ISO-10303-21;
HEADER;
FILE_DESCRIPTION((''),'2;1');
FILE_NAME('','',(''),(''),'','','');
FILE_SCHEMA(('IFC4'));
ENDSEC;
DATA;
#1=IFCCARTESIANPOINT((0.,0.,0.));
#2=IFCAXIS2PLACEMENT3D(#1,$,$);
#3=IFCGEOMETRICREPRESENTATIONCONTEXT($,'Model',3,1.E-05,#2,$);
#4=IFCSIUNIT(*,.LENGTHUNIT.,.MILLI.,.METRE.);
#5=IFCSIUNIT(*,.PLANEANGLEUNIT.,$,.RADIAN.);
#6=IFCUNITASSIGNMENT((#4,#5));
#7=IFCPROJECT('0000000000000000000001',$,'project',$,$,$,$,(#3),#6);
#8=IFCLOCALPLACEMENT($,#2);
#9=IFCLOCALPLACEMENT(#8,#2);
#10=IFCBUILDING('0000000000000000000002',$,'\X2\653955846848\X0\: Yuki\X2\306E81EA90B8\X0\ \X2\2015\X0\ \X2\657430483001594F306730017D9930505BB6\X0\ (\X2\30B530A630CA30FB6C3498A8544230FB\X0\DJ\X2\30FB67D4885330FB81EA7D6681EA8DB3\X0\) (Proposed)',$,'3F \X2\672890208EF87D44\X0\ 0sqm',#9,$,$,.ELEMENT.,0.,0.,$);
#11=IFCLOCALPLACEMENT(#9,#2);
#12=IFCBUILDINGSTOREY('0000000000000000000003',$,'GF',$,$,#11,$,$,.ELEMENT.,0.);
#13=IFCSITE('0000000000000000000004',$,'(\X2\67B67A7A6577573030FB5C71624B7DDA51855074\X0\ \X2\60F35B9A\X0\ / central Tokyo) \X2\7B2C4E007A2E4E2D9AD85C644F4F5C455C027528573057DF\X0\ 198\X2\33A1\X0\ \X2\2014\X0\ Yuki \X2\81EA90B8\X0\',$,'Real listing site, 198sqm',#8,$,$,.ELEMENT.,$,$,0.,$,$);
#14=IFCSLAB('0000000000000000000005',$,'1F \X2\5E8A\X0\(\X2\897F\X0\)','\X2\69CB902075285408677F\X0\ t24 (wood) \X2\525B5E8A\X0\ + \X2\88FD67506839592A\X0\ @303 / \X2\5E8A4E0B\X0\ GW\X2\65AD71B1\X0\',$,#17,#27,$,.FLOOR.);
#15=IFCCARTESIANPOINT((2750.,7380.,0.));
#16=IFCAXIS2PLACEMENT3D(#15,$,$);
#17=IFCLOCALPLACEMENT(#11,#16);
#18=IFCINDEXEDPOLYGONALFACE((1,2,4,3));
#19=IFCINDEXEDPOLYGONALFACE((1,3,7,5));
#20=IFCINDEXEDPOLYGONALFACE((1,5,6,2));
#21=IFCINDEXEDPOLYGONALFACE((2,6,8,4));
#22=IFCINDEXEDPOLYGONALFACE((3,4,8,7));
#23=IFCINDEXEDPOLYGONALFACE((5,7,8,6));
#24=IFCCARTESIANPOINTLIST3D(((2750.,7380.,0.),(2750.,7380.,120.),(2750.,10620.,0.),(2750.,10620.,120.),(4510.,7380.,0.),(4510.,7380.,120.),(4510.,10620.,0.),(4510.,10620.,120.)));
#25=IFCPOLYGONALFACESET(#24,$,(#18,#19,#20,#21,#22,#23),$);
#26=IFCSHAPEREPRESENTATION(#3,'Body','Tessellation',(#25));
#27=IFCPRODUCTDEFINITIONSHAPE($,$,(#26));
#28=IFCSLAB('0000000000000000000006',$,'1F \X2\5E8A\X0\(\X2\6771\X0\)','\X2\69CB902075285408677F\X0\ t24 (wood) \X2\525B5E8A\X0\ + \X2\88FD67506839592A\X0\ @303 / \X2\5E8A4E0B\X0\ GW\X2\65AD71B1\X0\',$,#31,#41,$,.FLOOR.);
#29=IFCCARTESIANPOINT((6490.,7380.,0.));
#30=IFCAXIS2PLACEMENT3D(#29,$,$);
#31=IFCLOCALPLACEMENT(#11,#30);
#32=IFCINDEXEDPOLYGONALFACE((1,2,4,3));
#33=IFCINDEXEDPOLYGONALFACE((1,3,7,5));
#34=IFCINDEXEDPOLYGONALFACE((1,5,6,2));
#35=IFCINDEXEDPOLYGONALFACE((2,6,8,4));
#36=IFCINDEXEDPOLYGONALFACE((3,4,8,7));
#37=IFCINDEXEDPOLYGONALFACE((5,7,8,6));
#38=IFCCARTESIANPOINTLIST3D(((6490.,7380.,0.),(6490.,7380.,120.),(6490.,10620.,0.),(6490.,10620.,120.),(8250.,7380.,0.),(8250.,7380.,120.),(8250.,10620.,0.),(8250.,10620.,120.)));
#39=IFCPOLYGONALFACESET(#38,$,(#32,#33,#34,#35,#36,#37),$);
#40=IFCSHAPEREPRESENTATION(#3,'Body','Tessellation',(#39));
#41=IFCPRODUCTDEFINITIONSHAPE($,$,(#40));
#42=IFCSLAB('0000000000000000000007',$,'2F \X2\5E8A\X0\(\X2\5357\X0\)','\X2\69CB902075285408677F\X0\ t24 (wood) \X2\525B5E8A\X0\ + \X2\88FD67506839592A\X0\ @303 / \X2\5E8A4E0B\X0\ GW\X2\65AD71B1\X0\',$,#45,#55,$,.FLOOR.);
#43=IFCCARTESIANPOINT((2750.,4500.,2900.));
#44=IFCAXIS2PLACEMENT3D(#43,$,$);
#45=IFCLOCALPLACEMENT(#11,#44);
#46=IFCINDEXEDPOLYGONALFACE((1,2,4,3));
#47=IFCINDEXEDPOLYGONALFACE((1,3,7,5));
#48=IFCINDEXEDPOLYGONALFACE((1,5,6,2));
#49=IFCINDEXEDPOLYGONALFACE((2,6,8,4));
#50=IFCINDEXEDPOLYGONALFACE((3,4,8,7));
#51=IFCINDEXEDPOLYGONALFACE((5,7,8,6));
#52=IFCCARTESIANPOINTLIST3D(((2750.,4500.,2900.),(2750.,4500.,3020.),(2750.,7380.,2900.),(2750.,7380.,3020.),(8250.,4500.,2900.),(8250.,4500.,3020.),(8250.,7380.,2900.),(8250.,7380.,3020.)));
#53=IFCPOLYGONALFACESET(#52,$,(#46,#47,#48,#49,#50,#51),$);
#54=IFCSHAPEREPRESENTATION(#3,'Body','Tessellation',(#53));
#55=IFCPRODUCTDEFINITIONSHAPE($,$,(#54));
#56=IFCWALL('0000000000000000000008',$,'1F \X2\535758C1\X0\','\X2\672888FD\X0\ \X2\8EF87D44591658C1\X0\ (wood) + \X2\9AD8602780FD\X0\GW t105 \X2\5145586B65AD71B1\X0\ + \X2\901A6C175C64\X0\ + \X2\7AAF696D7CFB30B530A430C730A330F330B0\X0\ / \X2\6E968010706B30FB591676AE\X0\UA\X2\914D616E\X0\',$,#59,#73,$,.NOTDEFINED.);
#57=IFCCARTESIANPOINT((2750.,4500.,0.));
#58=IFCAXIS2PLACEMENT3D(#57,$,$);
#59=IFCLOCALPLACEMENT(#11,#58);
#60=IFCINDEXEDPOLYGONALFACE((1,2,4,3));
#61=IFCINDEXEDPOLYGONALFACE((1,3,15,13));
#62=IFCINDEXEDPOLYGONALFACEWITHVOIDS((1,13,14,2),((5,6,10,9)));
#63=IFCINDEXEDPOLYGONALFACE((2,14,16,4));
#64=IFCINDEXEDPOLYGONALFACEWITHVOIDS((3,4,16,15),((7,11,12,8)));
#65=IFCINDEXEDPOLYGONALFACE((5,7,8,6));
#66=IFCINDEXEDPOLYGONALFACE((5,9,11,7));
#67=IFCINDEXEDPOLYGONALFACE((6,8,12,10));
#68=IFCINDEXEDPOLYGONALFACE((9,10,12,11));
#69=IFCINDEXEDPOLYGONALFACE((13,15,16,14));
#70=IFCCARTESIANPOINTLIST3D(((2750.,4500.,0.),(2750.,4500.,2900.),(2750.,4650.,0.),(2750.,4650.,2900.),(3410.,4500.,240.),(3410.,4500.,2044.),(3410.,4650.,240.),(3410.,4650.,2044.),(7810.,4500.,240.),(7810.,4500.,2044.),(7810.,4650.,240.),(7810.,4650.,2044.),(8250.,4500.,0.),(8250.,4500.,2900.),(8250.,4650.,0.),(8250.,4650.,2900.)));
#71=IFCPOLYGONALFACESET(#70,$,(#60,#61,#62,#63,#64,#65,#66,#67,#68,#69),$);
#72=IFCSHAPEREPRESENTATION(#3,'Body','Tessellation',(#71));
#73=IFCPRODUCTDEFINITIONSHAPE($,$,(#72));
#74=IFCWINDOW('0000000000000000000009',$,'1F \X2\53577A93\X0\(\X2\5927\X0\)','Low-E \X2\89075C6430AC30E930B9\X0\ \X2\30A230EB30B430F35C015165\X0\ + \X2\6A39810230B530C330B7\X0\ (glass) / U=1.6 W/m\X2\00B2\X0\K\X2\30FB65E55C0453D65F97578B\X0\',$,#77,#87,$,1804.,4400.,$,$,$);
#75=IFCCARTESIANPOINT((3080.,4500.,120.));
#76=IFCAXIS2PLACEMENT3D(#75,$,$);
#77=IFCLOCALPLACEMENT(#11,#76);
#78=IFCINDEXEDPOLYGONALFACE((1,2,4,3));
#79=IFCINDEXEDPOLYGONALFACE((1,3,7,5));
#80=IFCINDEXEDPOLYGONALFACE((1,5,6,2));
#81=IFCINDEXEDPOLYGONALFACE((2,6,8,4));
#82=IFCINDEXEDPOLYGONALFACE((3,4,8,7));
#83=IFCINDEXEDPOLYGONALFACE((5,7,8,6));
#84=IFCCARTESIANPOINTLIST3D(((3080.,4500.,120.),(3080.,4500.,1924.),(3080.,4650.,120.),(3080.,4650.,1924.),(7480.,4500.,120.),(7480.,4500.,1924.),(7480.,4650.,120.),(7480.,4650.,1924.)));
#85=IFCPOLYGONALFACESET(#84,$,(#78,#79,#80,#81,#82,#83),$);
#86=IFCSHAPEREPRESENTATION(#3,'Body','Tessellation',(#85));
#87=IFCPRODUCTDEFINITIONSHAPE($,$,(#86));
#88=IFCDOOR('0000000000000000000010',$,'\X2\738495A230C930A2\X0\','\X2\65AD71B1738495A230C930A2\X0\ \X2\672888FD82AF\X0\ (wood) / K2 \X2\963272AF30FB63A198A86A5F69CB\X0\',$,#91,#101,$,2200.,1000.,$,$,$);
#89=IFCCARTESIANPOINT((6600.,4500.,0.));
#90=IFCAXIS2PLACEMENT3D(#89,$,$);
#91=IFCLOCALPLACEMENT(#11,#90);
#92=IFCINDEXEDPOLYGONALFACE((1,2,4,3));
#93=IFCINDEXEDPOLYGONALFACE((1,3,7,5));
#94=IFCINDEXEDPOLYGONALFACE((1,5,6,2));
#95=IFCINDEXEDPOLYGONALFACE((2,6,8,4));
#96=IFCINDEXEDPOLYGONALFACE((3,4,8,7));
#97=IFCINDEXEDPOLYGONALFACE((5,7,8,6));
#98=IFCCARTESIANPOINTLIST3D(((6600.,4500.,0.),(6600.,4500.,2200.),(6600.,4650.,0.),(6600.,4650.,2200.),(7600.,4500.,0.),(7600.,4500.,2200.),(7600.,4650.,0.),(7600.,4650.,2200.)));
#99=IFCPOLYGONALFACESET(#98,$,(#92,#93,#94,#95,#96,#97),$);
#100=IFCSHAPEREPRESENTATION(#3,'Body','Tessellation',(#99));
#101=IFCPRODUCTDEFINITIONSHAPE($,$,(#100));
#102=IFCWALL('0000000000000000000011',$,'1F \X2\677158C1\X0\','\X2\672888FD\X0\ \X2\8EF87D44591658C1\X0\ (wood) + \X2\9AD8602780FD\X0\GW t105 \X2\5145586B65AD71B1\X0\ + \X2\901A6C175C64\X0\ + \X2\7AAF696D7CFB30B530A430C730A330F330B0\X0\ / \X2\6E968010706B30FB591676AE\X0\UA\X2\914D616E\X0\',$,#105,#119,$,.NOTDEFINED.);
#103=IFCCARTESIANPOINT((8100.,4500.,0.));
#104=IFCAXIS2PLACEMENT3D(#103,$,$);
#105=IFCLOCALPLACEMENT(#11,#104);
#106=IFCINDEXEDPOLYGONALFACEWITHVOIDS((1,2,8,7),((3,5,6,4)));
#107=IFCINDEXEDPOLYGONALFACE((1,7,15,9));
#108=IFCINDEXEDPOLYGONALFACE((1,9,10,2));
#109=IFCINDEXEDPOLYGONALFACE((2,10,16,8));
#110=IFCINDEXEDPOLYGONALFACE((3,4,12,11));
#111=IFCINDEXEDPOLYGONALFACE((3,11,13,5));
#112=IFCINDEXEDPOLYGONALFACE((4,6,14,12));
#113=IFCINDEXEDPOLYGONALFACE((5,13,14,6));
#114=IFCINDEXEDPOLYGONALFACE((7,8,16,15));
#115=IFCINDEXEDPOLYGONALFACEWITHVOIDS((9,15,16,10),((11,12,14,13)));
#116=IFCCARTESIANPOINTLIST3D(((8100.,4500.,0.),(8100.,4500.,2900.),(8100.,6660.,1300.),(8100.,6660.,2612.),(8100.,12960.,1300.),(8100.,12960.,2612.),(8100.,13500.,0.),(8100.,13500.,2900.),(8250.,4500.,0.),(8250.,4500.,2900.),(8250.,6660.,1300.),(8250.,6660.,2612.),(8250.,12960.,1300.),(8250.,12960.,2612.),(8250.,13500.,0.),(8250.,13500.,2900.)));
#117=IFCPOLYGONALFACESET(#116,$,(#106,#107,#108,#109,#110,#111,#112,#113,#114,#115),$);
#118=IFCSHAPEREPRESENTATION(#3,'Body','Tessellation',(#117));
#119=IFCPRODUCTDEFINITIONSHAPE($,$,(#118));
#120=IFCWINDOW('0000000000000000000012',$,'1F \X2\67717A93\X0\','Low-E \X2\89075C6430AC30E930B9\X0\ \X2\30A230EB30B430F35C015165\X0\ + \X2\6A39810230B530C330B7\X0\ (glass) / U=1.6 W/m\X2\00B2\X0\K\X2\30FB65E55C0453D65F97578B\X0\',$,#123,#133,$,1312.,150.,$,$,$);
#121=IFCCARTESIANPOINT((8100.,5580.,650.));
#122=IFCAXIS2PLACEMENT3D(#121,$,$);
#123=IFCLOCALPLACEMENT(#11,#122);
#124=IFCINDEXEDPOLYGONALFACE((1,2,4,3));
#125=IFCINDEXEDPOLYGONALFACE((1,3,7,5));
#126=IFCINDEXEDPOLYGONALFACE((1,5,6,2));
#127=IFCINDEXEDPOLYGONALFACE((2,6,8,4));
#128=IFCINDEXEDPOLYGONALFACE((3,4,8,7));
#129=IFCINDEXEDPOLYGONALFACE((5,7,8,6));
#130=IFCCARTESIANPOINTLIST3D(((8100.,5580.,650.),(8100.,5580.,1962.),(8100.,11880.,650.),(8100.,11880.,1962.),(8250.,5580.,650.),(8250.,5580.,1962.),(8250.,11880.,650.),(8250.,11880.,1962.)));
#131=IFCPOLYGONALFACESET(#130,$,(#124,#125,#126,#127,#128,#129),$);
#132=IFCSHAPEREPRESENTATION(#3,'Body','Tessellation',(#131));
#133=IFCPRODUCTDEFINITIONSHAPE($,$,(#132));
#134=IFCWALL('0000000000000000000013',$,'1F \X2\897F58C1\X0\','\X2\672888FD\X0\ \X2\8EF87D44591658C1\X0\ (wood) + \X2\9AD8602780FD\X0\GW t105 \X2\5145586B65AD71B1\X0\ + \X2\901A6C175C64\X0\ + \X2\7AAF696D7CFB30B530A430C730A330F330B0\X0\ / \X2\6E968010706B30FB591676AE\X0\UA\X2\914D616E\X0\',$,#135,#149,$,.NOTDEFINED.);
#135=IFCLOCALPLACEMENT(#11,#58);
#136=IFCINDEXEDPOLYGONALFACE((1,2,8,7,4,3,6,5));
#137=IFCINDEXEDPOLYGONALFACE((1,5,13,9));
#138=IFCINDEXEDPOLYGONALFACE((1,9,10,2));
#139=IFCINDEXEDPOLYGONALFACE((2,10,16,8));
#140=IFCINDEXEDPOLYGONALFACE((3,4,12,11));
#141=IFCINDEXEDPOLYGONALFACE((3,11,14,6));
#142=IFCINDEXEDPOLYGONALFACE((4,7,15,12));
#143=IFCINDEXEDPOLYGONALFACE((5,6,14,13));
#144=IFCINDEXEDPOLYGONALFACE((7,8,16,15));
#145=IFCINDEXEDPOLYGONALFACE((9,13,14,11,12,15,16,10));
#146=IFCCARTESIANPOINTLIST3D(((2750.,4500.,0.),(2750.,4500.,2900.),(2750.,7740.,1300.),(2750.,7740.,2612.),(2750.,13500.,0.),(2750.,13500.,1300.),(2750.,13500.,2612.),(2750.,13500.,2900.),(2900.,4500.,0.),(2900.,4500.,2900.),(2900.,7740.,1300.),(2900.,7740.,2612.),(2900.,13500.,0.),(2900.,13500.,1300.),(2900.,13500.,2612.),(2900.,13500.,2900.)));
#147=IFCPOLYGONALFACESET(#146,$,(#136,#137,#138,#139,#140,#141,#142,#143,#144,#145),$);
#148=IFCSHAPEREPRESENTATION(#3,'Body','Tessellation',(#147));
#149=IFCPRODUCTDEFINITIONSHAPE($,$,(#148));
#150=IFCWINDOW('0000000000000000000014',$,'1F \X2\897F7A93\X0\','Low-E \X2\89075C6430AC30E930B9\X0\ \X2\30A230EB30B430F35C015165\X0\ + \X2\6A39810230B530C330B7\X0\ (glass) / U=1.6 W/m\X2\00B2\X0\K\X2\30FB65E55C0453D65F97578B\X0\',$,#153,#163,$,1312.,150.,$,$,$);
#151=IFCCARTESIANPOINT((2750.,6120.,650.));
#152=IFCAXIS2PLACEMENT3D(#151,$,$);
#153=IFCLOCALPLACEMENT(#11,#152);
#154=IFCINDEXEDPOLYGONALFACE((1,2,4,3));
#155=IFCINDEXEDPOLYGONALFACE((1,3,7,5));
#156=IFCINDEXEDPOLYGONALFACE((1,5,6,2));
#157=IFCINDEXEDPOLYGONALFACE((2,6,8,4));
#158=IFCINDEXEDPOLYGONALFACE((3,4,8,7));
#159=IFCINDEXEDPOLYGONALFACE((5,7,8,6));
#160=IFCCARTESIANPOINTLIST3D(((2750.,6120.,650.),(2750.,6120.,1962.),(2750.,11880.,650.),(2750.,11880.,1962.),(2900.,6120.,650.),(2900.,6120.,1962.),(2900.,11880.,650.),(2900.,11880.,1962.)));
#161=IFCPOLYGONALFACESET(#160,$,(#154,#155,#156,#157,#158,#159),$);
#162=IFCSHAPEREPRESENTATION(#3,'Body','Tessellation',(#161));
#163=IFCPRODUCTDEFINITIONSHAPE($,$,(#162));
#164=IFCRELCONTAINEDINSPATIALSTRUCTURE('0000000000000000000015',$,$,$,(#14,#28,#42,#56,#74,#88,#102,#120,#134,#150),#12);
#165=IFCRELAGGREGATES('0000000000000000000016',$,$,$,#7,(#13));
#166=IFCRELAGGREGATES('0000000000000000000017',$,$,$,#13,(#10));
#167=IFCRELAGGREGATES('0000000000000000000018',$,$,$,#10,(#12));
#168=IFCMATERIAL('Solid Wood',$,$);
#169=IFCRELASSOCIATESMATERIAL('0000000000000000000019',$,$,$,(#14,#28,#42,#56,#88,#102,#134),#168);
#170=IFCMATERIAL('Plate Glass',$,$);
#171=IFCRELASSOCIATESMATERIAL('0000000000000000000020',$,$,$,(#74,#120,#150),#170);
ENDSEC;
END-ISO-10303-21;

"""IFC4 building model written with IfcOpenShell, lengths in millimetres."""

from ifc_helpers import new_model, si_unit, frame, frame_2d, origin, place, context, project, spatial, rectangle, extrude, material, element, fill, save


model = new_model("IFC4")

# Units and contexts
model_context = context("Model", 3, precision=1e-05, world=origin())
ifc_project = project(units=[si_unit("LENGTHUNIT", "METRE", prefix="MILLI"), si_unit("PLANEANGLEUNIT", "RADIAN")], contexts=[model_context])

# Site, building, storey
site_placement = place(None, origin())
site = spatial("IfcSite", under=ifc_project, at=site_placement, Name="(架空敷地・山手線内側 想定 / central Tokyo) 第一種中高層住居専用地域 198㎡ — Yuki 自邸", ObjectType="Real listing site, 198sqm", CompositionType="ELEMENT", RefElevation=0.0)
building_placement = place(site_placement, origin())
building = spatial("IfcBuilding", under=site, at=building_placement, Name="改善案: Yukiの自邸 ― 整え、奏で、継ぐ家 (サウナ・水風呂・DJ・柔術・自給自足) (Proposed)", ObjectType="3F 木造軸組 0sqm", CompositionType="ELEMENT", ElevationOfRefHeight=0.0, ElevationOfTerrain=0.0)
storey_placement = place(building_placement, origin())
storey = spatial("IfcBuildingStorey", under=building, at=storey_placement, Name="GF", CompositionType="ELEMENT", Elevation=0.0)

# Slabs
ifc_material_1 = material(Name="Solid Wood")
slab_1_placement = place(storey_placement, frame((2750.0, 7380.0, 0.0)))
element("IfcSlab", 1, at=slab_1_placement, inside=storey, material=ifc_material_1, Name="1F 床(西)", Description="構造用合板 t24 (wood) 剛床 + 製材根太 @303 / 床下 GW断熱", PredefinedType="FLOOR", context=model_context, shape_type="SweptSolid", body=[
    extrude(rectangle(XDim=1760.0, YDim=3240.0, at=frame_2d((880.0, 1620.0))), frame((2750.0, 7380.0, 0.0)), (0.0, 0.0, 1.0), 120.0),
])
slab_2_placement = place(storey_placement, frame((6490.0, 7380.0, 0.0)))
element("IfcSlab", 2, at=slab_2_placement, inside=storey, material=ifc_material_1, Name="1F 床(東)", Description="構造用合板 t24 (wood) 剛床 + 製材根太 @303 / 床下 GW断熱", PredefinedType="FLOOR", context=model_context, shape_type="SweptSolid", body=[
    extrude(rectangle(XDim=1760.0, YDim=3240.0, at=frame_2d((880.0, 1620.0))), frame((6490.0, 7380.0, 0.0)), (0.0, 0.0, 1.0), 120.0),
])
slab_3_placement = place(storey_placement, frame((2750.0, 4500.0, 2900.0)))
element("IfcSlab", 3, at=slab_3_placement, inside=storey, material=ifc_material_1, Name="2F 床(南)", Description="構造用合板 t24 (wood) 剛床 + 製材根太 @303 / 床下 GW断熱", PredefinedType="FLOOR", context=model_context, shape_type="SweptSolid", body=[
    extrude(rectangle(XDim=5500.0, YDim=2880.0, at=frame_2d((2750.0, 1440.0))), frame((2750.0, 4500.0, 2900.0)), (0.0, 0.0, 1.0), 120.0),
])

# Wall, openings, window, door
wall_1_placement = place(storey_placement, frame((2750.0, 4500.0, 0.0)))
wall_1 = element("IfcWall", 4, at=wall_1_placement, inside=storey, material=ifc_material_1, Name="1F 南壁", Description="木製 軸組外壁 (wood) + 高性能GW t105 充填断熱 + 通気層 + 窯業系サイディング / 準耐火・外皮UA配慮", PredefinedType="NOTDEFINED", context=model_context, shape_type="SweptSolid", body=[
    extrude(rectangle(XDim=5500.0, YDim=150.0, at=frame_2d((2750.0, 75.0))), frame((2750.0, 4500.0, 0.0)), (0.0, 0.0, 1.0), 2900.0),
])
opening_1_placement = place(storey_placement, frame((3080.0, 4500.0, 120.0)))
opening_1 = element("IfcOpeningElement", 5, at=opening_1_placement, cuts=wall_1, PredefinedType="NOTDEFINED", context=model_context, shape_type="SweptSolid", body=[
    extrude(rectangle(XDim=4400.0, YDim=150.0, at=frame_2d((2200.0, 75.0))), frame((3080.0, 4500.0, 120.0)), (0.0, 0.0, 1.0), 1804.0),
])
opening_2_placement = place(storey_placement, frame((6600.0, 4500.0, 0.0)))
opening_2 = element("IfcOpeningElement", 6, at=opening_2_placement, cuts=wall_1, PredefinedType="NOTDEFINED", context=model_context, shape_type="SweptSolid", body=[
    extrude(rectangle(XDim=1000.0, YDim=150.0, at=frame_2d((500.0, 75.0))), frame((6600.0, 4500.0, 0.0)), (0.0, 0.0, 1.0), 2200.0),
])
ifc_material_2 = material(Name="Plate Glass")
window_1_placement = place(storey_placement, frame((3080.0, 4500.0, 120.0)))
window_1 = element("IfcWindow", 7, at=window_1_placement, inside=storey, material=ifc_material_2, Name="1F 南窓(大)", Description="Low-E 複層ガラス アルゴン封入 + 樹脂サッシ (glass) / U=1.6 W/m²K・日射取得型", OverallHeight=1804.0, OverallWidth=4400.0, context=model_context, shape_type="SweptSolid", body=[
    extrude(rectangle(XDim=4400.0, YDim=150.0, at=frame_2d((2200.0, 75.0))), frame((3080.0, 4500.0, 120.0)), (0.0, 0.0, 1.0), 1804.0),
])
fill(opening_1, window_1)
door_placement = place(storey_placement, frame((6600.0, 4500.0, 0.0)))
door = element("IfcDoor", 8, at=door_placement, inside=storey, material=ifc_material_1, Name="玄関ドア", Description="断熱玄関ドア 木製芯 (wood) / K2 防犯・採風機構", OverallHeight=2200.0, OverallWidth=1000.0, context=model_context, shape_type="SweptSolid", body=[
    extrude(rectangle(XDim=1000.0, YDim=150.0, at=frame_2d((500.0, 75.0))), frame((6600.0, 4500.0, 0.0)), (0.0, 0.0, 1.0), 2200.0),
])
fill(opening_2, door)

# Walls, openings, windows
wall_2_placement = place(storey_placement, frame((8100.0, 4500.0, 0.0)))
wall_2 = element("IfcWall", 9, at=wall_2_placement, inside=storey, material=ifc_material_1, Name="1F 東壁", Description="木製 軸組外壁 (wood) + 高性能GW t105 充填断熱 + 通気層 + 窯業系サイディング / 準耐火・外皮UA配慮", PredefinedType="NOTDEFINED", context=model_context, shape_type="SweptSolid", body=[
    extrude(rectangle(XDim=150.0, YDim=9000.0, at=frame_2d((75.0, 4500.0))), frame((8100.0, 4500.0, 0.0)), (0.0, 0.0, 1.0), 2900.0),
])
opening_3_placement = place(storey_placement, frame((8100.0, 5580.0, 650.0)))
opening_3 = element("IfcOpeningElement", 10, at=opening_3_placement, cuts=wall_2, PredefinedType="NOTDEFINED", context=model_context, shape_type="SweptSolid", body=[
    extrude(rectangle(XDim=150.0, YDim=6300.0, at=frame_2d((75.0, 3150.0))), frame((8100.0, 5580.0, 650.0)), (0.0, 0.0, 1.0), 1312.0),
])
window_2_placement = place(storey_placement, frame((8100.0, 5580.0, 650.0)))
window_2 = element("IfcWindow", 11, at=window_2_placement, inside=storey, material=ifc_material_2, Name="1F 東窓", Description="Low-E 複層ガラス アルゴン封入 + 樹脂サッシ (glass) / U=1.6 W/m²K・日射取得型", OverallHeight=1312.0, OverallWidth=150.0, context=model_context, shape_type="SweptSolid", body=[
    extrude(rectangle(XDim=150.0, YDim=6300.0, at=frame_2d((75.0, 3150.0))), frame((8100.0, 5580.0, 650.0)), (0.0, 0.0, 1.0), 1312.0),
])
fill(opening_3, window_2)
wall_3_placement = place(storey_placement, frame((2750.0, 4500.0, 0.0)))
wall_3 = element("IfcWall", 12, at=wall_3_placement, inside=storey, material=ifc_material_1, Name="1F 西壁", Description="木製 軸組外壁 (wood) + 高性能GW t105 充填断熱 + 通気層 + 窯業系サイディング / 準耐火・外皮UA配慮", PredefinedType="NOTDEFINED", context=model_context, shape_type="SweptSolid", body=[
    extrude(rectangle(XDim=150.0, YDim=9000.0, at=frame_2d((75.0, 4500.0))), frame((2750.0, 4500.0, 0.0)), (0.0, 0.0, 1.0), 2900.0),
])
opening_4_placement = place(storey_placement, frame((2750.0, 6120.0, 650.0)))
opening_4 = element("IfcOpeningElement", 13, at=opening_4_placement, cuts=wall_3, PredefinedType="NOTDEFINED", context=model_context, shape_type="SweptSolid", body=[
    extrude(rectangle(XDim=150.0, YDim=5760.0, at=frame_2d((75.0, 2880.0))), frame((2750.0, 6120.0, 650.0)), (0.0, 0.0, 1.0), 1312.0),
])
window_3_placement = place(storey_placement, frame((2750.0, 6120.0, 650.0)))
window_3 = element("IfcWindow", 14, at=window_3_placement, inside=storey, material=ifc_material_2, Name="1F 西窓", Description="Low-E 複層ガラス アルゴン封入 + 樹脂サッシ (glass) / U=1.6 W/m²K・日射取得型", OverallHeight=1312.0, OverallWidth=150.0, context=model_context, shape_type="SweptSolid", body=[
    extrude(rectangle(XDim=150.0, YDim=5760.0, at=frame_2d((75.0, 2880.0))), frame((2750.0, 6120.0, 650.0)), (0.0, 0.0, 1.0), 1312.0),
])
fill(opening_4, window_3)

save(model, "model.ifc")
